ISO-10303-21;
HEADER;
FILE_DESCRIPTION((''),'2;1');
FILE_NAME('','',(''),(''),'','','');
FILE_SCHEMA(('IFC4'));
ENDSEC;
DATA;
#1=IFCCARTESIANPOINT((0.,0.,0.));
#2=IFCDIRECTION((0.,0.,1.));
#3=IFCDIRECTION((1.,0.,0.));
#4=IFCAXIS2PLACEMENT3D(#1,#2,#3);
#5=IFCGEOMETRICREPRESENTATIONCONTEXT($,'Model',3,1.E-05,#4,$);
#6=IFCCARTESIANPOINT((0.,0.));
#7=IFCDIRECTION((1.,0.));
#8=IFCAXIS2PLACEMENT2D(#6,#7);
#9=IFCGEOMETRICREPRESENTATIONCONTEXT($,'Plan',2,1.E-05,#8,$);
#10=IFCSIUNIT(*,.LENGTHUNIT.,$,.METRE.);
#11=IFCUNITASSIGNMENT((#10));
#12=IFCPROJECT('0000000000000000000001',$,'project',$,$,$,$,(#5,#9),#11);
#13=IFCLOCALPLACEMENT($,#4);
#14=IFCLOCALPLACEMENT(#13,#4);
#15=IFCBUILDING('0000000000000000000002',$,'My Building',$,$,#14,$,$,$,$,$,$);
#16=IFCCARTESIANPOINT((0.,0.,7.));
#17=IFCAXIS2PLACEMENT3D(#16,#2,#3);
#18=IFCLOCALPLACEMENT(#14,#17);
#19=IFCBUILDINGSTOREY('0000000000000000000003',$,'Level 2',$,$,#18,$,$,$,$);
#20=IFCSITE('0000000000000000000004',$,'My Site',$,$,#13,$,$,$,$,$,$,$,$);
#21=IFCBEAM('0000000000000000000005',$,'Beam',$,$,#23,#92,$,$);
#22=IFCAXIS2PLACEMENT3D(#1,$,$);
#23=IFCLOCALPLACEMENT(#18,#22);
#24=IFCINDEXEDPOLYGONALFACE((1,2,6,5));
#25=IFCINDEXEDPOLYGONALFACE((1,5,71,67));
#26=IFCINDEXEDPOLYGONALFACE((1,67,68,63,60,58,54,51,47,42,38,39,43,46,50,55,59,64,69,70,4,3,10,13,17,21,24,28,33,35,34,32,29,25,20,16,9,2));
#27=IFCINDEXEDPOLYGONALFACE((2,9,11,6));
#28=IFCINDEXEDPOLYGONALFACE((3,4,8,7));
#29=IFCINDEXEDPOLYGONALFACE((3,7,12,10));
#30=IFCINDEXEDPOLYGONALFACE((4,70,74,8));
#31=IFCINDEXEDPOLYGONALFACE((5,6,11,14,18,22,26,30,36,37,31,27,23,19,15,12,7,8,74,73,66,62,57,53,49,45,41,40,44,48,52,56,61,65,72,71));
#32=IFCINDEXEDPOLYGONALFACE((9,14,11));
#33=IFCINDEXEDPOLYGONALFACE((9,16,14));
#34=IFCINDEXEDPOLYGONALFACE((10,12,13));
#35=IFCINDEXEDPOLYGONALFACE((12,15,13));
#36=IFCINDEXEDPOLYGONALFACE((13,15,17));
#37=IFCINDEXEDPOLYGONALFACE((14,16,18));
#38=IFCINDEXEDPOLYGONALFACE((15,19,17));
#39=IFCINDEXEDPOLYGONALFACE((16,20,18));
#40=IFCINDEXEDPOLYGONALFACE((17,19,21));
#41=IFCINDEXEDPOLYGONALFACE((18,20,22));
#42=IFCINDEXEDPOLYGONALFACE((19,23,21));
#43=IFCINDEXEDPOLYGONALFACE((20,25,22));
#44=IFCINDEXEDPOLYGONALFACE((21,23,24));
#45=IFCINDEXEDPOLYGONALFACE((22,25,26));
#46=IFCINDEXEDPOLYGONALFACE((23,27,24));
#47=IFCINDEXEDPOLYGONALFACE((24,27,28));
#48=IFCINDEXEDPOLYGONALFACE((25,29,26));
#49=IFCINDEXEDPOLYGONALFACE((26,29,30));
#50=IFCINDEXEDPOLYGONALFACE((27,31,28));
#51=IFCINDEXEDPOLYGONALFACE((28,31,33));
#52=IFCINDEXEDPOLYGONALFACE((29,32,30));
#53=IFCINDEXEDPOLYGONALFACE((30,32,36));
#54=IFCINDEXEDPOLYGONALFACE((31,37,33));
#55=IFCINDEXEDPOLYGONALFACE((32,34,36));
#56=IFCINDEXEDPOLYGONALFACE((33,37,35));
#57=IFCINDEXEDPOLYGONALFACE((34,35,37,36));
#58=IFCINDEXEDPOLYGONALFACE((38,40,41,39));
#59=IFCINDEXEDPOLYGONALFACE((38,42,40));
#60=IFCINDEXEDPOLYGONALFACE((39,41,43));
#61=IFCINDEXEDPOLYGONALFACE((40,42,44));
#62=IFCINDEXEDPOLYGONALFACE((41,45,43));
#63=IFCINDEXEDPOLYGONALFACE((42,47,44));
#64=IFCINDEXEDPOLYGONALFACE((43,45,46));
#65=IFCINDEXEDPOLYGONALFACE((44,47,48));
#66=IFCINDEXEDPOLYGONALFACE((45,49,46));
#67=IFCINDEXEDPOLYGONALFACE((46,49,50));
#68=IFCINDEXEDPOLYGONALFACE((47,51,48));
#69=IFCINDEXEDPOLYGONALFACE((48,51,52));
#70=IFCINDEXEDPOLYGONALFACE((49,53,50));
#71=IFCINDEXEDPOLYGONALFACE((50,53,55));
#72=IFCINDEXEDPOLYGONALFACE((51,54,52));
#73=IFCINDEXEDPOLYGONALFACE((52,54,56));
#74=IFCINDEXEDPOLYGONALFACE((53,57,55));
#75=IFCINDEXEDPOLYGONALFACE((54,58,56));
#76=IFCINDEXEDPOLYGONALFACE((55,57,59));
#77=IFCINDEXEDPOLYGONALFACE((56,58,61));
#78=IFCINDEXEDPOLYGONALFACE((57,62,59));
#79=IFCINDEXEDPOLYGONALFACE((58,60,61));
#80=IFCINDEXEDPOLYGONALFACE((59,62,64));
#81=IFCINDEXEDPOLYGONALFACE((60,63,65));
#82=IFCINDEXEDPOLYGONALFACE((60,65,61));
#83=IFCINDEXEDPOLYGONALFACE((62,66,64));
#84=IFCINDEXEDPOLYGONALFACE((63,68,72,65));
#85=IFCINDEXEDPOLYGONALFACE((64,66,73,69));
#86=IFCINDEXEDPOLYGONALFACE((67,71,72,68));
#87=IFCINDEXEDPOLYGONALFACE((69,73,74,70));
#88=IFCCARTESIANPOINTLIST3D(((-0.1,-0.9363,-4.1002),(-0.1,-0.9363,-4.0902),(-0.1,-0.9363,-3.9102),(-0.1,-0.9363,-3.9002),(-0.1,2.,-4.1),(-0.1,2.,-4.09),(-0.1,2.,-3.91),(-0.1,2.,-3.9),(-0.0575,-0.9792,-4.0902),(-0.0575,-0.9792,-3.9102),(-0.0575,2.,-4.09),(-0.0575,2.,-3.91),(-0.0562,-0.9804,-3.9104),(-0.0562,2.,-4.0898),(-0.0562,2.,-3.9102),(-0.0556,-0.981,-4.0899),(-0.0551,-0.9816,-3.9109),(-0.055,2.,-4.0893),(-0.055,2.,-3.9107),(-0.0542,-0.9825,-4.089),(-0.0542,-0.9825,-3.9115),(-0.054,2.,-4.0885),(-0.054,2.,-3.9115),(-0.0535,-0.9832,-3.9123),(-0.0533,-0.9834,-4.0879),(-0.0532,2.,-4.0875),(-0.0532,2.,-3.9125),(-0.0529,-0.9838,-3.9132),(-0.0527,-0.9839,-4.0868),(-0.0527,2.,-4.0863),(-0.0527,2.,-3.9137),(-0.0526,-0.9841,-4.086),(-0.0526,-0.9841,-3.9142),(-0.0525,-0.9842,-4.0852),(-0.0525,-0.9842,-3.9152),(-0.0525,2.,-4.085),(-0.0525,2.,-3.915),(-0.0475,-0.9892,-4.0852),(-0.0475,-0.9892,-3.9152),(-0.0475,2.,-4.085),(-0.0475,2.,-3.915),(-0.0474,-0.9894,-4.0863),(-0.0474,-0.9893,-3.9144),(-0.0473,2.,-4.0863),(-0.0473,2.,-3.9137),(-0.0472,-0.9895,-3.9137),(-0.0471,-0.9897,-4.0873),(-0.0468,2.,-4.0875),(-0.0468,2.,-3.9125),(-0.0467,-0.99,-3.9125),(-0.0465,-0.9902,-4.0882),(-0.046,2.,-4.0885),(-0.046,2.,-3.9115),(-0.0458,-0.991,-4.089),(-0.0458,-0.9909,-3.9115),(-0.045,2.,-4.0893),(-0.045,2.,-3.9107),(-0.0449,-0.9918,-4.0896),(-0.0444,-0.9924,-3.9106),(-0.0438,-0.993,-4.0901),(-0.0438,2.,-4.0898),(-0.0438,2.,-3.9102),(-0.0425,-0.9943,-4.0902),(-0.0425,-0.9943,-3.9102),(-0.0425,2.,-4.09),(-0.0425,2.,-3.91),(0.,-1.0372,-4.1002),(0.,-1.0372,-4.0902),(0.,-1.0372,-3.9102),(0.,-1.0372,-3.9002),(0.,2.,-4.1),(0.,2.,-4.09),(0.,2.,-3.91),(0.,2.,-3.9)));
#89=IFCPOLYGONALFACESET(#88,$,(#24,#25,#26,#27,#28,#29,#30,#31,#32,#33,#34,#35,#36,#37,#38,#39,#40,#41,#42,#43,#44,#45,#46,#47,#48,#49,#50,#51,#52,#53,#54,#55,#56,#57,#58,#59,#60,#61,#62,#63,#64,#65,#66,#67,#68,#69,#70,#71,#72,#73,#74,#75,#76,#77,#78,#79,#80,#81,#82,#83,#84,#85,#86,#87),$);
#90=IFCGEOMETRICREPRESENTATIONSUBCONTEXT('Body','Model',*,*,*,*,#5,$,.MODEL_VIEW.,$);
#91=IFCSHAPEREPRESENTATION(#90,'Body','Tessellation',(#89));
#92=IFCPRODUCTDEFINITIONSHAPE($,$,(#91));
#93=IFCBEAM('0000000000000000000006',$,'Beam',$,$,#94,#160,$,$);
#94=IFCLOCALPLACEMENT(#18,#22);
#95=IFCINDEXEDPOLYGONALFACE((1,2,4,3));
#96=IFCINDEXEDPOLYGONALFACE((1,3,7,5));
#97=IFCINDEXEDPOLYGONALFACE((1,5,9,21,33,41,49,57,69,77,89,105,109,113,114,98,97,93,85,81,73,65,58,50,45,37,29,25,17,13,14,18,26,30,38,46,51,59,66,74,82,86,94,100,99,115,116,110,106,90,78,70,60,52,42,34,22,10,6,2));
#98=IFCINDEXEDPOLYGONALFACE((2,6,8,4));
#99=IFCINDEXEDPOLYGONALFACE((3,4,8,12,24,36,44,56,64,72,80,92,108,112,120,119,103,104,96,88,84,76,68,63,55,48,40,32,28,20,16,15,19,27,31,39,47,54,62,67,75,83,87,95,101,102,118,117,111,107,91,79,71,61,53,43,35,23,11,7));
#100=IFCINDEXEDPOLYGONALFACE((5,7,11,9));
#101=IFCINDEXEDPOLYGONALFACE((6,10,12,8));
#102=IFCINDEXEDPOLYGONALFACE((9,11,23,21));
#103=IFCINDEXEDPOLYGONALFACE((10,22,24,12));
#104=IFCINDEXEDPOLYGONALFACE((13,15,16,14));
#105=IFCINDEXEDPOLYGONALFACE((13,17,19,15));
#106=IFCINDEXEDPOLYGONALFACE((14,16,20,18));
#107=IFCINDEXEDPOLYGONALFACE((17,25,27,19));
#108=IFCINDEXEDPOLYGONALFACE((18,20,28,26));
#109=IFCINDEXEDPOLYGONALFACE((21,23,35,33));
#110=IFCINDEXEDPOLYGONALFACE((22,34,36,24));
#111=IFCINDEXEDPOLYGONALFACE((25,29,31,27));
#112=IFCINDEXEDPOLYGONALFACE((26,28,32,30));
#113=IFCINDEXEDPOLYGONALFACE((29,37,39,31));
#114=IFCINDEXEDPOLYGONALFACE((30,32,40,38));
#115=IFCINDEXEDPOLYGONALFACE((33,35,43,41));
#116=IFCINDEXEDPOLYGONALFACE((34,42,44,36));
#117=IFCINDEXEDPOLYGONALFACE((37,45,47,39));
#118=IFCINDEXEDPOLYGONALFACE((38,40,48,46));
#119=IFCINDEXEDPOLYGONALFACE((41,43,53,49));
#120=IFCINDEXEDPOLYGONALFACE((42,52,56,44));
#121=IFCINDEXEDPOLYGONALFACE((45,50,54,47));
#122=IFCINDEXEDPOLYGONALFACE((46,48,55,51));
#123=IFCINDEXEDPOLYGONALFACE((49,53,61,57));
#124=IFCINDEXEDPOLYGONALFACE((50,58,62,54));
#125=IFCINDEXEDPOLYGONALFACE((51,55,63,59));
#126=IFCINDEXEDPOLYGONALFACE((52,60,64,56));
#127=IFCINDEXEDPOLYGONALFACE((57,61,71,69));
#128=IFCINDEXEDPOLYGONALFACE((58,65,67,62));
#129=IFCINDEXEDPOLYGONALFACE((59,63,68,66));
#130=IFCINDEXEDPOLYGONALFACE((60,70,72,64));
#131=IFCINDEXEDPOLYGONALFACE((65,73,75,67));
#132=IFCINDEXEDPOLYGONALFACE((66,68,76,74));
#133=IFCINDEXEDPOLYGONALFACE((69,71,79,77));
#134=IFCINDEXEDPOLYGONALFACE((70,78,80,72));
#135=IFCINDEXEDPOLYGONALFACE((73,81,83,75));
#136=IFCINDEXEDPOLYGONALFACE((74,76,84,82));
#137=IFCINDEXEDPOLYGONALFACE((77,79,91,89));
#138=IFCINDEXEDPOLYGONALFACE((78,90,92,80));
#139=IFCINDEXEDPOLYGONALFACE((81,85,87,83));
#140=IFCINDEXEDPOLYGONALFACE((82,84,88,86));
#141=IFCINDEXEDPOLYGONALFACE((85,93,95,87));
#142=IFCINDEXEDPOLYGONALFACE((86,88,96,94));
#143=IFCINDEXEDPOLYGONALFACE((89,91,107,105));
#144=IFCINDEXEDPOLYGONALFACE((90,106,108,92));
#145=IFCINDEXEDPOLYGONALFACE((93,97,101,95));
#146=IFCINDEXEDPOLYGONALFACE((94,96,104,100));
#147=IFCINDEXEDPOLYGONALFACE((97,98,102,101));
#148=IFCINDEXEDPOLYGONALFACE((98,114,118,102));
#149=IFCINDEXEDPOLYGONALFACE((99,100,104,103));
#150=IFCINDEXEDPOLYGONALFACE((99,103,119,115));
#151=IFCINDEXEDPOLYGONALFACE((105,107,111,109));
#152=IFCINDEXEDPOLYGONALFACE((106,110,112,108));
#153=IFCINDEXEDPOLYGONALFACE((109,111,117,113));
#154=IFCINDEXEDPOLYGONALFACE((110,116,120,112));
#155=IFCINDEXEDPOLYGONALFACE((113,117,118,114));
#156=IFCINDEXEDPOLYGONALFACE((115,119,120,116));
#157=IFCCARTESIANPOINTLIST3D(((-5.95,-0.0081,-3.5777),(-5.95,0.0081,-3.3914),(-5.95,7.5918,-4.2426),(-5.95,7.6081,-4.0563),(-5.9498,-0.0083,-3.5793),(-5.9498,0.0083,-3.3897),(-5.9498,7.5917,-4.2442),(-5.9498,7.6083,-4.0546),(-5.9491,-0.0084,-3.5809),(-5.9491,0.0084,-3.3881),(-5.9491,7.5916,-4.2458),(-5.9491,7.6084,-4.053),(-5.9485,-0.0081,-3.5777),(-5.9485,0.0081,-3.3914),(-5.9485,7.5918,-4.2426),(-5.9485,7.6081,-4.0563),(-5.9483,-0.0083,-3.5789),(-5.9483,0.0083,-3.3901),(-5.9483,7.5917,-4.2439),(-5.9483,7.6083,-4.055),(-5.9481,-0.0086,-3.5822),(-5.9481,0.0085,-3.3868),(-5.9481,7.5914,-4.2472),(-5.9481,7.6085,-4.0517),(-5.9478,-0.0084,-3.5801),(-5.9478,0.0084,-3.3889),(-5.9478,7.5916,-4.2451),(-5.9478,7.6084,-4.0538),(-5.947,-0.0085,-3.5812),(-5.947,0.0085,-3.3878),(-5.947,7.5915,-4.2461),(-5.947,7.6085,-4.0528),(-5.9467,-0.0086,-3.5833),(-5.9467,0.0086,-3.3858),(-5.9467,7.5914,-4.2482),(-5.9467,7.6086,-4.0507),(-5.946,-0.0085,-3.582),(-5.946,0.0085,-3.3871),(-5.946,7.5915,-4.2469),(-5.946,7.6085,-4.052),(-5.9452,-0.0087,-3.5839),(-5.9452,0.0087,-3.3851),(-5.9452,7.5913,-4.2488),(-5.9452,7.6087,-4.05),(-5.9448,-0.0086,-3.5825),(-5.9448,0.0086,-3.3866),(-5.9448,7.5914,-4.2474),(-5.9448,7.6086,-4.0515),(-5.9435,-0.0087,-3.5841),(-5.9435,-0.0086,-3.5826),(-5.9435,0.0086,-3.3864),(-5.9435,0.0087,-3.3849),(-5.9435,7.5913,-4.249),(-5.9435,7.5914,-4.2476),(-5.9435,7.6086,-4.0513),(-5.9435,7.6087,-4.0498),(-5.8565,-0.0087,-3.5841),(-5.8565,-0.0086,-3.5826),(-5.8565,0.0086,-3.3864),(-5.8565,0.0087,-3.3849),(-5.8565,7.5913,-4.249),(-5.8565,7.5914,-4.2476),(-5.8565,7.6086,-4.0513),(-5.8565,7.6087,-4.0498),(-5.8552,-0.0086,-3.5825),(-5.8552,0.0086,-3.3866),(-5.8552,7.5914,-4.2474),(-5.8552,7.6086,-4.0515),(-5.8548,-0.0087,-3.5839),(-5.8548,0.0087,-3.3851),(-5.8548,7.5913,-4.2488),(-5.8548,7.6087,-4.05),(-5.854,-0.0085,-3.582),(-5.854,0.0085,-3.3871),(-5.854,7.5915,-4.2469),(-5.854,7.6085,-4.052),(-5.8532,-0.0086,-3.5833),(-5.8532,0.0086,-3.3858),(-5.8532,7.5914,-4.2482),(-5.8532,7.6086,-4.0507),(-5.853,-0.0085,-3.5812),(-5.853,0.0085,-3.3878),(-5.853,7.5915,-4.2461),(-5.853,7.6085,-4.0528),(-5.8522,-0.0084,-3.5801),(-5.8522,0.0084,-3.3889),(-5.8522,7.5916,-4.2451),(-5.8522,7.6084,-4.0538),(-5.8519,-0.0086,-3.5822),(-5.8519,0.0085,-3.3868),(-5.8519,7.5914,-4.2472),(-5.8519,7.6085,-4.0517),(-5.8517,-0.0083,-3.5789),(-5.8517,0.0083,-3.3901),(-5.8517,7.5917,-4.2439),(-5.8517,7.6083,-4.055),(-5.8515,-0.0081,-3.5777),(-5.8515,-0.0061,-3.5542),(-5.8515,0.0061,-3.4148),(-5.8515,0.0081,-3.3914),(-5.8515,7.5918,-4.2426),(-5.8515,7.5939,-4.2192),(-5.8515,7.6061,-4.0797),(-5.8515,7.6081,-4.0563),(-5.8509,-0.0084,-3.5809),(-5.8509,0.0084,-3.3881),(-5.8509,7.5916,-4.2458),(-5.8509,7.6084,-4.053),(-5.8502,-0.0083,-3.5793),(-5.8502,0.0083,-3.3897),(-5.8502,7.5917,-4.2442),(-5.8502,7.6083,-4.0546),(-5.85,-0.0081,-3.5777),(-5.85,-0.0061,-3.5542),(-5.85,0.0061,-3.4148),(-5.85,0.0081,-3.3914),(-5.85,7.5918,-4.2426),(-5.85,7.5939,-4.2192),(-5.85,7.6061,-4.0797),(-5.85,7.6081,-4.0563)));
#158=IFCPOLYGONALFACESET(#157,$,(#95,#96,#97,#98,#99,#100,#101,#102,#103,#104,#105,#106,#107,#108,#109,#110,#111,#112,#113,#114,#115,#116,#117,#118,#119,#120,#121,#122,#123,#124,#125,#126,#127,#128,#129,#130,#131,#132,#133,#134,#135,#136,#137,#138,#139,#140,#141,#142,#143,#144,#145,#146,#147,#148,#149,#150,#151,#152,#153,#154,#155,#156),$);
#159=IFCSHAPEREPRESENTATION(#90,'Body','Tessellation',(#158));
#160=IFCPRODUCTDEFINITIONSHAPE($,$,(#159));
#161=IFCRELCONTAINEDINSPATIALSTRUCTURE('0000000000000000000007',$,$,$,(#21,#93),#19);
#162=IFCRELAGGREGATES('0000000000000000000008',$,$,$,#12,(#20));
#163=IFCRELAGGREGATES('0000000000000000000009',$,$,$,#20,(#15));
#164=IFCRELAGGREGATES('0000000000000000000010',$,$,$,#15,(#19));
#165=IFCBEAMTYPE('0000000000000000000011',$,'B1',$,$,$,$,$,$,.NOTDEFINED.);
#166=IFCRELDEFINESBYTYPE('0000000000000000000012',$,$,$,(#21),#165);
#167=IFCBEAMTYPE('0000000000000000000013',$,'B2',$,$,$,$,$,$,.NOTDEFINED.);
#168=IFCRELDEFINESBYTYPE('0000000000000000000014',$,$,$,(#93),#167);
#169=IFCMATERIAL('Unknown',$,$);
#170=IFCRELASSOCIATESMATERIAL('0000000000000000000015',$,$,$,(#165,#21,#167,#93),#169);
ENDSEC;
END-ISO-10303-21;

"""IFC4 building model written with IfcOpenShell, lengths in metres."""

from ifc_helpers import new_model, si_unit, frame, origin_with_axes, origin_2d_with_axis, place, context, subcontext, project, spatial, i_section, c_section, extrude, clip, halfspace, material, material_profile, profile_set, profile_usage, type_object, element, save


model = new_model("IFC4")

# Units and contexts
model_context = context("Model", 3, precision=1e-05, world=origin_with_axes())
plan_context = context("Plan", 2, precision=1e-05, world=origin_2d_with_axis())
body_context = subcontext(model_context, "Body", "Model", "MODEL_VIEW")
ifc_project = project(units=[si_unit("LENGTHUNIT", "METRE")], contexts=[model_context, plan_context])

# Site, building, storey
site_placement = place(None, origin_with_axes())
site = spatial("IfcSite", under=ifc_project, at=site_placement, Name="My Site")
building_placement = place(site_placement, origin_with_axes())
building = spatial("IfcBuilding", under=site, at=building_placement, Name="My Building")
storey_placement = place(building_placement, frame((0.0, 0.0, 7.0), z_axis=(0.0, 0.0, 1.0), x_axis=(1.0, 0.0, 0.0)))
storey = spatial("IfcBuildingStorey", under=building, at=storey_placement, Name="Level 2")

# Shared definitions
ifc_material = material(Name="Unknown")

# Beams
ifc_material_profile_1 = material_profile(ifc_material, i_section(OverallWidth=0.1, OverallDepth=0.2, WebThickness=0.005, FlangeThickness=0.01, FilletRadius=0.005))
ifc_profile_set_1 = profile_set([ifc_material_profile_1])
beam_type_1 = type_object("IfcBeamType", Name="B1", PredefinedType="NOTDEFINED", material=ifc_profile_set_1)
ifc_profile_usage_1 = profile_usage(ifc_profile_set_1, cardinal=5)
beam_1_placement = place(storey_placement, frame((-0.05, -1.2367, -4.0002), z_axis=(0.0, 1.0, 0.000074), x_axis=(-1.0, 0.0, 0.0)))
element("IfcBeam", 1, at=beam_1_placement, inside=storey, type_object=beam_type_1, material=ifc_profile_usage_1, Name="Beam", context=body_context, shape_type="Clipping", body=[
    clip(extrude(i_section(OverallWidth=0.1, OverallDepth=0.2, WebThickness=0.005, FlangeThickness=0.01, FilletRadius=0.005), origin_with_axes(), (0.0, 0.0, 1.0), 3.2367), halfspace(frame((-0.05, -2.9998, 0.1993), z_axis=(0.710333, 0.000052, -0.703866), x_axis=(0.000073, -1.0, 0.0)), False)),
])
ifc_material_profile_2 = material_profile(ifc_material, c_section(Depth=0.2, Width=0.1, WallThickness=0.0015, Girth=0.03, InternalFilletRadius=0.005))
ifc_profile_set_2 = profile_set([ifc_material_profile_2])
ifc_profile_usage_2 = profile_usage(ifc_profile_set_2, cardinal=5)
beam_type_2 = type_object("IfcBeamType", Name="B2", PredefinedType="NOTDEFINED", material=ifc_profile_set_2)
beam_2_placement = place(storey_placement, frame((-5.9, 7.6, -4.1494), z_axis=(0.0, -0.996195, 0.087156), x_axis=(1.0, 0.0, 0.0)))
element("IfcBeam", 2, at=beam_2_placement, inside=storey, type_object=beam_type_2, material=ifc_profile_usage_2, Name="Beam", context=body_context, shape_type="SweptSolid", body=[
    extrude(c_section(Depth=0.2, Width=0.1, WallThickness=0.0015, Girth=0.03, InternalFilletRadius=0.005), origin_with_axes(), (0.0, 0.0, 1.0), 7.629),
])

save(model, "model.ifc")
